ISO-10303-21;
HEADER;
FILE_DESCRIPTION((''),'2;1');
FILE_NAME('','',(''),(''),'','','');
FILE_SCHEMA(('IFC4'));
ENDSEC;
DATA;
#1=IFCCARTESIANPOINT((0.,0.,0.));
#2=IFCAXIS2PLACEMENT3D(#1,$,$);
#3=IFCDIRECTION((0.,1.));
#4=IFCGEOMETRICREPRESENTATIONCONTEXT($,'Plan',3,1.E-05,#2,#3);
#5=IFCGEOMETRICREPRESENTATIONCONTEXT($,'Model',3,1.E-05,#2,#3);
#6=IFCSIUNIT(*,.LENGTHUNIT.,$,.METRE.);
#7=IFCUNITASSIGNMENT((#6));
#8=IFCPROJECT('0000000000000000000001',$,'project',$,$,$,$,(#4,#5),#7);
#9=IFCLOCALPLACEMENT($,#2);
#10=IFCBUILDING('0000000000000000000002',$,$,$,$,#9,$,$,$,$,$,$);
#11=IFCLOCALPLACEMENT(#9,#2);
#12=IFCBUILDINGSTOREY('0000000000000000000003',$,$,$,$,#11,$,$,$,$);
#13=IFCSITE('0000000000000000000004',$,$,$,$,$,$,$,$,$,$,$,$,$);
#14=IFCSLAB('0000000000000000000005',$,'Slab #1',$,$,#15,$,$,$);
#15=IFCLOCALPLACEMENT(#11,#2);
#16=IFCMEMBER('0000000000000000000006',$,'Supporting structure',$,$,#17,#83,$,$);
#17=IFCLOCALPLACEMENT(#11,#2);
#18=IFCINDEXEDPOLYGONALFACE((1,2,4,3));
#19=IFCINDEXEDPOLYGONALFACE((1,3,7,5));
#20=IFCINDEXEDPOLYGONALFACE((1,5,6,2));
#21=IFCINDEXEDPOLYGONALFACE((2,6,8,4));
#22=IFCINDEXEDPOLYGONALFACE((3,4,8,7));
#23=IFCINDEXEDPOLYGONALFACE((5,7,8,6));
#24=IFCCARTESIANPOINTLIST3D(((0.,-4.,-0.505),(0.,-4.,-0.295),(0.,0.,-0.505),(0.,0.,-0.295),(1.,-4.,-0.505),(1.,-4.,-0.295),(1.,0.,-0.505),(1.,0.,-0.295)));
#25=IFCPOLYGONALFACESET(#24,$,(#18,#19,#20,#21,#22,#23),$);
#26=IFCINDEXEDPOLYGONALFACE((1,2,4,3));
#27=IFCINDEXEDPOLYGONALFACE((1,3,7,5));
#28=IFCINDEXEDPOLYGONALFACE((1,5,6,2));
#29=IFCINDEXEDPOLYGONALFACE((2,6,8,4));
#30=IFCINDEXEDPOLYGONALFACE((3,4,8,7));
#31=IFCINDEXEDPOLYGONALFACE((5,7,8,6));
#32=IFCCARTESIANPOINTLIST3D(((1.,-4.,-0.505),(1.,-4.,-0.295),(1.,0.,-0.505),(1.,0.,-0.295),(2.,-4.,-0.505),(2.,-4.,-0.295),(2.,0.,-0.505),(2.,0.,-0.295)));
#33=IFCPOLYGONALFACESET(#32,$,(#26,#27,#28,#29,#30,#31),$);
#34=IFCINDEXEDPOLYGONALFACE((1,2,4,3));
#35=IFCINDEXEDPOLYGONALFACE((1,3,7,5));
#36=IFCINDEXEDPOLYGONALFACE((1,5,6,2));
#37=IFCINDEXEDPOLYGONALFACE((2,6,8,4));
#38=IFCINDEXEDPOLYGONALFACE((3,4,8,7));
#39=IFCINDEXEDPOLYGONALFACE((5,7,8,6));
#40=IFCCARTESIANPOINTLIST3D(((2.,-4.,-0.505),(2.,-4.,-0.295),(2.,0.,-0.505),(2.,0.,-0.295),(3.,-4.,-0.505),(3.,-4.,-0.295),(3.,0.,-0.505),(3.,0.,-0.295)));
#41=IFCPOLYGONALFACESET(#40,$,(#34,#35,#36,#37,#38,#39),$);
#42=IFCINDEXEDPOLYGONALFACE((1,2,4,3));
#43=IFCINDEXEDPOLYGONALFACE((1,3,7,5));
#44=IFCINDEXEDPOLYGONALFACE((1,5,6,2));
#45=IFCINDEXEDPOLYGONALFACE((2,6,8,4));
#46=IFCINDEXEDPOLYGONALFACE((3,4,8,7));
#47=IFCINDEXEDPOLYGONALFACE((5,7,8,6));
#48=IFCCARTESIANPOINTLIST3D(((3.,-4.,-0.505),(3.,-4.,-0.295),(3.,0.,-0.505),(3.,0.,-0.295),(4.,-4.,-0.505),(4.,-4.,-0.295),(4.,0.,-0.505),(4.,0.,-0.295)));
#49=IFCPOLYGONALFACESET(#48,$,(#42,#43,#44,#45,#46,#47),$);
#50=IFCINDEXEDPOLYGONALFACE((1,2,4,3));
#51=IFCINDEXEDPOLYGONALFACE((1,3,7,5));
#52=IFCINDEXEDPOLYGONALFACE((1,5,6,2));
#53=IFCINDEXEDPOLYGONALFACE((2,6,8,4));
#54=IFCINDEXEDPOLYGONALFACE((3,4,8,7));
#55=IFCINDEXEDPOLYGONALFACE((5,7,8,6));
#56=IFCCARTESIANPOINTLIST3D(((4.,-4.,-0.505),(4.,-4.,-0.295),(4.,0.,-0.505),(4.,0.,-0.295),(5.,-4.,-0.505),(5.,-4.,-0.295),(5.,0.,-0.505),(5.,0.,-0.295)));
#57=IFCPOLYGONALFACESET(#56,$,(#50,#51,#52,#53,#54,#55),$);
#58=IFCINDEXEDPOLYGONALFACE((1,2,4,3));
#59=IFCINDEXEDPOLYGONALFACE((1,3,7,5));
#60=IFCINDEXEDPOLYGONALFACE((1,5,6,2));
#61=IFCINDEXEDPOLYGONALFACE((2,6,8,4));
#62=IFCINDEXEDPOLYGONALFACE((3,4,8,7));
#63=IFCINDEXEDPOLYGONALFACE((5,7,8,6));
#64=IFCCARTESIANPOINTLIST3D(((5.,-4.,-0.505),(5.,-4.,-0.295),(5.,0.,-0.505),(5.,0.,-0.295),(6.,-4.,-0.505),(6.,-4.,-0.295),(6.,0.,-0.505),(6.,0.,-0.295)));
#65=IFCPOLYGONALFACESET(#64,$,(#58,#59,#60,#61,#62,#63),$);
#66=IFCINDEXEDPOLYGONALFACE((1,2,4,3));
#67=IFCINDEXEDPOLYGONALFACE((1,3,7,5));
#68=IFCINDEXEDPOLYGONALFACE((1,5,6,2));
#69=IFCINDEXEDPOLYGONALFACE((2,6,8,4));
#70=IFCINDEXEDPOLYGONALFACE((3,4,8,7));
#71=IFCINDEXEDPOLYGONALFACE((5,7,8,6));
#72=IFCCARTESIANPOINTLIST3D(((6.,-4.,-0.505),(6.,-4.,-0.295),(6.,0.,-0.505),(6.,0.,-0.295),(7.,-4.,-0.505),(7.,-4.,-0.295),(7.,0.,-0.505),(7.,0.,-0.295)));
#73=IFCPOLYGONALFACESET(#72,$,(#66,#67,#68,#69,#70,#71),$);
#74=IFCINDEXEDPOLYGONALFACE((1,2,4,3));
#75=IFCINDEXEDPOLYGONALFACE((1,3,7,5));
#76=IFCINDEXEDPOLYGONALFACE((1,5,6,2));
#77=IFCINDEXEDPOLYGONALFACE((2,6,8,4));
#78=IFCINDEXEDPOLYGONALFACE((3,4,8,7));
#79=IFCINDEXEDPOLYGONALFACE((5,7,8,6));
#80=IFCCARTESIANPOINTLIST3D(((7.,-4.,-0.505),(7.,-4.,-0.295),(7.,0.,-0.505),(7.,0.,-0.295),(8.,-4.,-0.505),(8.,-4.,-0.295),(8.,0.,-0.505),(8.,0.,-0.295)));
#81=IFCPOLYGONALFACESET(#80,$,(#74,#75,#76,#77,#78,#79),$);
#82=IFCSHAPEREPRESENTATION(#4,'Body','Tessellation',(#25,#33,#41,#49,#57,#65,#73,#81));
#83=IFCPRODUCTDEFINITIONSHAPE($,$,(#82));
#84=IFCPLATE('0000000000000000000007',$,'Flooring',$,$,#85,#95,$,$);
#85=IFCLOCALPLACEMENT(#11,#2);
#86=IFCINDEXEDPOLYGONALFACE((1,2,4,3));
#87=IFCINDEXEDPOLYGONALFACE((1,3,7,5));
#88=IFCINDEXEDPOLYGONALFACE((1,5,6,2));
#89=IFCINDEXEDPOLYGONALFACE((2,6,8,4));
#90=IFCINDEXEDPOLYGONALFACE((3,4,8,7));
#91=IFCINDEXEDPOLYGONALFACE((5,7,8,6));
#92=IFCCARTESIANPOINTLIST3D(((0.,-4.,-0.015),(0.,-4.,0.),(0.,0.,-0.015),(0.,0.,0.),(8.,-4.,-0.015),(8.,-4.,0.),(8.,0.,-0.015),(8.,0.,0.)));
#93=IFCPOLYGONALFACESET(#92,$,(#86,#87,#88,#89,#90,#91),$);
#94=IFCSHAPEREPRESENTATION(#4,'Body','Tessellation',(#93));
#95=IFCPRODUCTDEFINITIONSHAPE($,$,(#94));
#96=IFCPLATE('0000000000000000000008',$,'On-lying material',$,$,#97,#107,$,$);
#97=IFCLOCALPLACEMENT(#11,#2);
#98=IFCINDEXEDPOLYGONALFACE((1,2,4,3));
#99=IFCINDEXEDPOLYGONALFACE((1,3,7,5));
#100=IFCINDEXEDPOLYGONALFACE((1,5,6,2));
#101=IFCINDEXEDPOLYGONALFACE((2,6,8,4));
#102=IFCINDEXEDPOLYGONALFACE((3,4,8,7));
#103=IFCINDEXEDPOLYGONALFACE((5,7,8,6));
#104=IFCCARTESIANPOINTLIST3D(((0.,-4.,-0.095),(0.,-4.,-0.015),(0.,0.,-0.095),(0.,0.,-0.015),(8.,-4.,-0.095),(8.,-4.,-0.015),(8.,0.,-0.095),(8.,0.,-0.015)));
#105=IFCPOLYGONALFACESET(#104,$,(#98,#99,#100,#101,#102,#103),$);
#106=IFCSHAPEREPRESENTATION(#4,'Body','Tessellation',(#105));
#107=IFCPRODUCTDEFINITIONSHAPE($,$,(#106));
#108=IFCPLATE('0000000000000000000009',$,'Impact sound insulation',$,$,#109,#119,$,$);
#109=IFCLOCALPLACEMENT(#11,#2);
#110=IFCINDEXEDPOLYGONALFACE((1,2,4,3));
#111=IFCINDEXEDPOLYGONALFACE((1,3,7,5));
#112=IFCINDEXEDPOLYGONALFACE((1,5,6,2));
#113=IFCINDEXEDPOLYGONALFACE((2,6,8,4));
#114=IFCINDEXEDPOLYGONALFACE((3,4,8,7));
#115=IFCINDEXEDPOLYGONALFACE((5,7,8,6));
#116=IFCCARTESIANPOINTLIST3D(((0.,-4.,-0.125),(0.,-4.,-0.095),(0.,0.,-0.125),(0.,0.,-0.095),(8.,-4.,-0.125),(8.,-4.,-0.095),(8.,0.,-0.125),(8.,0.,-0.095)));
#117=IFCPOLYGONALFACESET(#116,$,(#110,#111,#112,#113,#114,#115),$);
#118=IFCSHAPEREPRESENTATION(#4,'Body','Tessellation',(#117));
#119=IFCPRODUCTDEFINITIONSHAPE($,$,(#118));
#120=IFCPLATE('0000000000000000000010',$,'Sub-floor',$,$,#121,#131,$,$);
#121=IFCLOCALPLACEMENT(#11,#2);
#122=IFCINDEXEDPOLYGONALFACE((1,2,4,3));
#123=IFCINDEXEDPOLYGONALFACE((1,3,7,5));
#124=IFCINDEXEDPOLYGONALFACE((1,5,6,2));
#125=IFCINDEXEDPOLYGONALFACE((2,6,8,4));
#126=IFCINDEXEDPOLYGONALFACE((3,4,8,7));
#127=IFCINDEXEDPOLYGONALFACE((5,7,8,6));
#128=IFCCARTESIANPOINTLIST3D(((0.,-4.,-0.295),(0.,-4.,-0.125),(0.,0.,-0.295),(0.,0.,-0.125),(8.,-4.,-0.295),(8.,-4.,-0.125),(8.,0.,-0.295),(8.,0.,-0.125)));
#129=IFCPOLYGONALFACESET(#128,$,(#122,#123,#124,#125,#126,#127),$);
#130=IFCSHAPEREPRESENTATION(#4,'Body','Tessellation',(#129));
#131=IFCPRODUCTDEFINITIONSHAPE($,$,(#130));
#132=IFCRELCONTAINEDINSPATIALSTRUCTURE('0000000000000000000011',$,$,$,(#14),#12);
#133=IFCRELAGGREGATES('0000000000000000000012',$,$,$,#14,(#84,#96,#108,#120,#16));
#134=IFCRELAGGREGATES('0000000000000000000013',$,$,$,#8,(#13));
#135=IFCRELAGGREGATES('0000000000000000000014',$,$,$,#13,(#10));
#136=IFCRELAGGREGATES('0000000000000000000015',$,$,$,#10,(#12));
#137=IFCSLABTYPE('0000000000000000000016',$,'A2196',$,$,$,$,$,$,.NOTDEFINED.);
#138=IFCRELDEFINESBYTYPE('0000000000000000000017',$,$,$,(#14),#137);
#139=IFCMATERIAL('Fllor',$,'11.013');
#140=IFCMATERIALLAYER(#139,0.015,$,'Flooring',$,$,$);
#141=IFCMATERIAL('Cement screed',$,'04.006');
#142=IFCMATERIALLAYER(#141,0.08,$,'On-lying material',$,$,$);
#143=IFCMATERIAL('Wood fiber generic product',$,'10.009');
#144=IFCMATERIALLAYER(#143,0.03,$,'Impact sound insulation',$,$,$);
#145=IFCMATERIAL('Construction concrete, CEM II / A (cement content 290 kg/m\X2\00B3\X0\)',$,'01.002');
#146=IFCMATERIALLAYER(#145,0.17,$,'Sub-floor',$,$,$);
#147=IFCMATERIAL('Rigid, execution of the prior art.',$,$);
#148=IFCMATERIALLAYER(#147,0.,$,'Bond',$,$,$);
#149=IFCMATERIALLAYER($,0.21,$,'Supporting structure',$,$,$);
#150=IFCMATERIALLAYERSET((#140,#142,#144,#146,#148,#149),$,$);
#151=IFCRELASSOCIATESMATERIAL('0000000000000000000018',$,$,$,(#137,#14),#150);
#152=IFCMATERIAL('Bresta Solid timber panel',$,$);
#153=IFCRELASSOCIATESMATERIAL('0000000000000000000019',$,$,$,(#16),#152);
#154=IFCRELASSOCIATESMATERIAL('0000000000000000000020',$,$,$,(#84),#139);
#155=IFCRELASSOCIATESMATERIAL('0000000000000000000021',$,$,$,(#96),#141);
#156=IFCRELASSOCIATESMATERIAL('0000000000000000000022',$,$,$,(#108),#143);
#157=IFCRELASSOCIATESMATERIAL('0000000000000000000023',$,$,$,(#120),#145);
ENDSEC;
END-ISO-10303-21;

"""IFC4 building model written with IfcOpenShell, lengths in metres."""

from ifc_helpers import new_model, si_unit, direction, frame, frame_2d, origin, origin_with_axes, place, context, project, spatial, rectangle, extrude, material, layer, layer_set, type_object, element, aggregate, save


model = new_model("IFC4")

# Units and contexts
plan_context = context("Plan", 3, precision=1e-05, world=origin(), true_north=direction((0.0, 1.0)))
model_context = context("Model", 3, precision=1e-05, world=origin(), true_north=direction((0.0, 1.0)))
ifc_project = project(units=[si_unit("LENGTHUNIT", "METRE")], contexts=[plan_context, model_context])

# Site, building, storey
site = spatial("IfcSite", under=ifc_project)
building_placement = place(None, origin())
building = spatial("IfcBuilding", under=site, at=building_placement)
storey_placement = place(building_placement, origin())
storey = spatial("IfcBuildingStorey", under=building, at=storey_placement)

# Slab, member, plates
ifc_material_1 = material(Name="Fllor", Category="11.013")
ifc_layer_1 = layer(ifc_material_1, 0.015, Name="Flooring")
ifc_material_2 = material(Name="Cement screed", Category="04.006")
ifc_layer_2 = layer(ifc_material_2, 0.08, Name="On-lying material")
ifc_material_3 = material(Name="Wood fiber generic product", Category="10.009")
ifc_layer_3 = layer(ifc_material_3, 0.03, Name="Impact sound insulation")
ifc_material_4 = material(Name="Construction concrete, CEM II / A (cement content 290 kg/m³)", Category="01.002")
ifc_layer_4 = layer(ifc_material_4, 0.17, Name="Sub-floor")
ifc_material_5 = material(Name="Rigid, execution of the prior art.")
ifc_layer_5 = layer(ifc_material_5, 0.0, Name="Bond")
ifc_layer_6 = layer(None, 0.21, Name="Supporting structure")
ifc_layer_set = layer_set([ifc_layer_1, ifc_layer_2, ifc_layer_3, ifc_layer_4, ifc_layer_5, ifc_layer_6])
slab_type = type_object("IfcSlabType", Name="A2196", PredefinedType="NOTDEFINED", material=ifc_layer_set)
slab_placement = place(None, frame((0.0, 0.0, 0.0), z_axis=(0.0, 0.0, -1.0), x_axis=(1.0, 0.0, 0.0)))
slab = element("IfcSlab", 1, at=slab_placement, inside=storey, type_object=slab_type, material=ifc_layer_set, Name="Slab #1")
ifc_material_6 = material(Name="Bresta Solid timber panel")
member_placement = place(slab_placement, origin())
member = element("IfcMember", 2, at=member_placement, material=ifc_material_6, Name="Supporting structure", context=plan_context, shape_type="SweptSolid", body=[
    extrude(rectangle(XDim=1.0, YDim=0.21, at=frame_2d((0.5, 0.105), x_axis=(1.0, 0.0))), frame((0.0, 4.0, 0.295), z_axis=(0.0, -1.0, 0.0), x_axis=(1.0, 0.0, 0.0)), (0.0, 0.0, 1.0), 4.0),
    extrude(rectangle(XDim=1.0, YDim=0.21, at=frame_2d((0.5, 0.105), x_axis=(1.0, 0.0))), frame((1.0, 4.0, 0.295), z_axis=(0.0, -1.0, 0.0), x_axis=(1.0, 0.0, 0.0)), (0.0, 0.0, 1.0), 4.0),
    extrude(rectangle(XDim=1.0, YDim=0.21, at=frame_2d((0.5, 0.105), x_axis=(1.0, 0.0))), frame((2.0, 4.0, 0.295), z_axis=(0.0, -1.0, 0.0), x_axis=(1.0, 0.0, 0.0)), (0.0, 0.0, 1.0), 4.0),
    extrude(rectangle(XDim=1.0, YDim=0.21, at=frame_2d((0.5, 0.105), x_axis=(1.0, 0.0))), frame((3.0, 4.0, 0.295), z_axis=(0.0, -1.0, 0.0), x_axis=(1.0, 0.0, 0.0)), (0.0, 0.0, 1.0), 4.0),
    extrude(rectangle(XDim=1.0, YDim=0.21, at=frame_2d((0.5, 0.105), x_axis=(1.0, 0.0))), frame((4.0, 4.0, 0.295), z_axis=(0.0, -1.0, 0.0), x_axis=(1.0, 0.0, 0.0)), (0.0, 0.0, 1.0), 4.0),
    extrude(rectangle(XDim=1.0, YDim=0.21, at=frame_2d((0.5, 0.105), x_axis=(1.0, 0.0))), frame((5.0, 4.0, 0.295), z_axis=(0.0, -1.0, 0.0), x_axis=(1.0, 0.0, 0.0)), (0.0, 0.0, 1.0), 4.0),
    extrude(rectangle(XDim=1.0, YDim=0.21, at=frame_2d((0.5, 0.105), x_axis=(1.0, 0.0))), frame((6.0, 4.0, 0.295), z_axis=(0.0, -1.0, 0.0), x_axis=(1.0, 0.0, 0.0)), (0.0, 0.0, 1.0), 4.0),
    extrude(rectangle(XDim=1.0, YDim=0.21, at=frame_2d((0.5, 0.105), x_axis=(1.0, 0.0))), frame((7.0, 4.0, 0.295), z_axis=(0.0, -1.0, 0.0), x_axis=(1.0, 0.0, 0.0)), (0.0, 0.0, 1.0), 4.0),
])
plate_1_placement = place(slab_placement, origin())
plate_1 = element("IfcPlate", 3, at=plate_1_placement, material=ifc_material_1, Name="Flooring", context=plan_context, shape_type="SweptSolid", body=[
    extrude(rectangle(XDim=8.0, YDim=4.0, at=frame_2d((4.0, 2.0), x_axis=(1.0, 0.0))), origin_with_axes(), (0.0, 0.0, 1.0), 0.015),
])
plate_2_placement = place(slab_placement, origin())
plate_2 = element("IfcPlate", 4, at=plate_2_placement, material=ifc_material_2, Name="On-lying material", context=plan_context, shape_type="SweptSolid", body=[
    extrude(rectangle(XDim=8.0, YDim=4.0, at=frame_2d((4.0, 2.0), x_axis=(1.0, 0.0))), frame((0.0, 0.0, 0.015), z_axis=(0.0, 0.0, 1.0), x_axis=(1.0, 0.0, 0.0)), (0.0, 0.0, 1.0), 0.08),
])
plate_3_placement = place(slab_placement, origin())
plate_3 = element("IfcPlate", 5, at=plate_3_placement, material=ifc_material_3, Name="Impact sound insulation", context=plan_context, shape_type="SweptSolid", body=[
    extrude(rectangle(XDim=8.0, YDim=4.0, at=frame_2d((4.0, 2.0), x_axis=(1.0, 0.0))), frame((0.0, 0.0, 0.095), z_axis=(0.0, 0.0, 1.0), x_axis=(1.0, 0.0, 0.0)), (0.0, 0.0, 1.0), 0.03),
])
plate_4_placement = place(slab_placement, origin())
plate_4 = element("IfcPlate", 6, at=plate_4_placement, material=ifc_material_4, Name="Sub-floor", context=plan_context, shape_type="SweptSolid", body=[
    extrude(rectangle(XDim=8.0, YDim=4.0, at=frame_2d((4.0, 2.0), x_axis=(1.0, 0.0))), frame((0.0, 0.0, 0.125), z_axis=(0.0, 0.0, 1.0), x_axis=(1.0, 0.0, 0.0)), (0.0, 0.0, 1.0), 0.17),
])
aggregate(slab, [plate_1, plate_2, plate_3, plate_4, member])

save(model, "model.ifc")
